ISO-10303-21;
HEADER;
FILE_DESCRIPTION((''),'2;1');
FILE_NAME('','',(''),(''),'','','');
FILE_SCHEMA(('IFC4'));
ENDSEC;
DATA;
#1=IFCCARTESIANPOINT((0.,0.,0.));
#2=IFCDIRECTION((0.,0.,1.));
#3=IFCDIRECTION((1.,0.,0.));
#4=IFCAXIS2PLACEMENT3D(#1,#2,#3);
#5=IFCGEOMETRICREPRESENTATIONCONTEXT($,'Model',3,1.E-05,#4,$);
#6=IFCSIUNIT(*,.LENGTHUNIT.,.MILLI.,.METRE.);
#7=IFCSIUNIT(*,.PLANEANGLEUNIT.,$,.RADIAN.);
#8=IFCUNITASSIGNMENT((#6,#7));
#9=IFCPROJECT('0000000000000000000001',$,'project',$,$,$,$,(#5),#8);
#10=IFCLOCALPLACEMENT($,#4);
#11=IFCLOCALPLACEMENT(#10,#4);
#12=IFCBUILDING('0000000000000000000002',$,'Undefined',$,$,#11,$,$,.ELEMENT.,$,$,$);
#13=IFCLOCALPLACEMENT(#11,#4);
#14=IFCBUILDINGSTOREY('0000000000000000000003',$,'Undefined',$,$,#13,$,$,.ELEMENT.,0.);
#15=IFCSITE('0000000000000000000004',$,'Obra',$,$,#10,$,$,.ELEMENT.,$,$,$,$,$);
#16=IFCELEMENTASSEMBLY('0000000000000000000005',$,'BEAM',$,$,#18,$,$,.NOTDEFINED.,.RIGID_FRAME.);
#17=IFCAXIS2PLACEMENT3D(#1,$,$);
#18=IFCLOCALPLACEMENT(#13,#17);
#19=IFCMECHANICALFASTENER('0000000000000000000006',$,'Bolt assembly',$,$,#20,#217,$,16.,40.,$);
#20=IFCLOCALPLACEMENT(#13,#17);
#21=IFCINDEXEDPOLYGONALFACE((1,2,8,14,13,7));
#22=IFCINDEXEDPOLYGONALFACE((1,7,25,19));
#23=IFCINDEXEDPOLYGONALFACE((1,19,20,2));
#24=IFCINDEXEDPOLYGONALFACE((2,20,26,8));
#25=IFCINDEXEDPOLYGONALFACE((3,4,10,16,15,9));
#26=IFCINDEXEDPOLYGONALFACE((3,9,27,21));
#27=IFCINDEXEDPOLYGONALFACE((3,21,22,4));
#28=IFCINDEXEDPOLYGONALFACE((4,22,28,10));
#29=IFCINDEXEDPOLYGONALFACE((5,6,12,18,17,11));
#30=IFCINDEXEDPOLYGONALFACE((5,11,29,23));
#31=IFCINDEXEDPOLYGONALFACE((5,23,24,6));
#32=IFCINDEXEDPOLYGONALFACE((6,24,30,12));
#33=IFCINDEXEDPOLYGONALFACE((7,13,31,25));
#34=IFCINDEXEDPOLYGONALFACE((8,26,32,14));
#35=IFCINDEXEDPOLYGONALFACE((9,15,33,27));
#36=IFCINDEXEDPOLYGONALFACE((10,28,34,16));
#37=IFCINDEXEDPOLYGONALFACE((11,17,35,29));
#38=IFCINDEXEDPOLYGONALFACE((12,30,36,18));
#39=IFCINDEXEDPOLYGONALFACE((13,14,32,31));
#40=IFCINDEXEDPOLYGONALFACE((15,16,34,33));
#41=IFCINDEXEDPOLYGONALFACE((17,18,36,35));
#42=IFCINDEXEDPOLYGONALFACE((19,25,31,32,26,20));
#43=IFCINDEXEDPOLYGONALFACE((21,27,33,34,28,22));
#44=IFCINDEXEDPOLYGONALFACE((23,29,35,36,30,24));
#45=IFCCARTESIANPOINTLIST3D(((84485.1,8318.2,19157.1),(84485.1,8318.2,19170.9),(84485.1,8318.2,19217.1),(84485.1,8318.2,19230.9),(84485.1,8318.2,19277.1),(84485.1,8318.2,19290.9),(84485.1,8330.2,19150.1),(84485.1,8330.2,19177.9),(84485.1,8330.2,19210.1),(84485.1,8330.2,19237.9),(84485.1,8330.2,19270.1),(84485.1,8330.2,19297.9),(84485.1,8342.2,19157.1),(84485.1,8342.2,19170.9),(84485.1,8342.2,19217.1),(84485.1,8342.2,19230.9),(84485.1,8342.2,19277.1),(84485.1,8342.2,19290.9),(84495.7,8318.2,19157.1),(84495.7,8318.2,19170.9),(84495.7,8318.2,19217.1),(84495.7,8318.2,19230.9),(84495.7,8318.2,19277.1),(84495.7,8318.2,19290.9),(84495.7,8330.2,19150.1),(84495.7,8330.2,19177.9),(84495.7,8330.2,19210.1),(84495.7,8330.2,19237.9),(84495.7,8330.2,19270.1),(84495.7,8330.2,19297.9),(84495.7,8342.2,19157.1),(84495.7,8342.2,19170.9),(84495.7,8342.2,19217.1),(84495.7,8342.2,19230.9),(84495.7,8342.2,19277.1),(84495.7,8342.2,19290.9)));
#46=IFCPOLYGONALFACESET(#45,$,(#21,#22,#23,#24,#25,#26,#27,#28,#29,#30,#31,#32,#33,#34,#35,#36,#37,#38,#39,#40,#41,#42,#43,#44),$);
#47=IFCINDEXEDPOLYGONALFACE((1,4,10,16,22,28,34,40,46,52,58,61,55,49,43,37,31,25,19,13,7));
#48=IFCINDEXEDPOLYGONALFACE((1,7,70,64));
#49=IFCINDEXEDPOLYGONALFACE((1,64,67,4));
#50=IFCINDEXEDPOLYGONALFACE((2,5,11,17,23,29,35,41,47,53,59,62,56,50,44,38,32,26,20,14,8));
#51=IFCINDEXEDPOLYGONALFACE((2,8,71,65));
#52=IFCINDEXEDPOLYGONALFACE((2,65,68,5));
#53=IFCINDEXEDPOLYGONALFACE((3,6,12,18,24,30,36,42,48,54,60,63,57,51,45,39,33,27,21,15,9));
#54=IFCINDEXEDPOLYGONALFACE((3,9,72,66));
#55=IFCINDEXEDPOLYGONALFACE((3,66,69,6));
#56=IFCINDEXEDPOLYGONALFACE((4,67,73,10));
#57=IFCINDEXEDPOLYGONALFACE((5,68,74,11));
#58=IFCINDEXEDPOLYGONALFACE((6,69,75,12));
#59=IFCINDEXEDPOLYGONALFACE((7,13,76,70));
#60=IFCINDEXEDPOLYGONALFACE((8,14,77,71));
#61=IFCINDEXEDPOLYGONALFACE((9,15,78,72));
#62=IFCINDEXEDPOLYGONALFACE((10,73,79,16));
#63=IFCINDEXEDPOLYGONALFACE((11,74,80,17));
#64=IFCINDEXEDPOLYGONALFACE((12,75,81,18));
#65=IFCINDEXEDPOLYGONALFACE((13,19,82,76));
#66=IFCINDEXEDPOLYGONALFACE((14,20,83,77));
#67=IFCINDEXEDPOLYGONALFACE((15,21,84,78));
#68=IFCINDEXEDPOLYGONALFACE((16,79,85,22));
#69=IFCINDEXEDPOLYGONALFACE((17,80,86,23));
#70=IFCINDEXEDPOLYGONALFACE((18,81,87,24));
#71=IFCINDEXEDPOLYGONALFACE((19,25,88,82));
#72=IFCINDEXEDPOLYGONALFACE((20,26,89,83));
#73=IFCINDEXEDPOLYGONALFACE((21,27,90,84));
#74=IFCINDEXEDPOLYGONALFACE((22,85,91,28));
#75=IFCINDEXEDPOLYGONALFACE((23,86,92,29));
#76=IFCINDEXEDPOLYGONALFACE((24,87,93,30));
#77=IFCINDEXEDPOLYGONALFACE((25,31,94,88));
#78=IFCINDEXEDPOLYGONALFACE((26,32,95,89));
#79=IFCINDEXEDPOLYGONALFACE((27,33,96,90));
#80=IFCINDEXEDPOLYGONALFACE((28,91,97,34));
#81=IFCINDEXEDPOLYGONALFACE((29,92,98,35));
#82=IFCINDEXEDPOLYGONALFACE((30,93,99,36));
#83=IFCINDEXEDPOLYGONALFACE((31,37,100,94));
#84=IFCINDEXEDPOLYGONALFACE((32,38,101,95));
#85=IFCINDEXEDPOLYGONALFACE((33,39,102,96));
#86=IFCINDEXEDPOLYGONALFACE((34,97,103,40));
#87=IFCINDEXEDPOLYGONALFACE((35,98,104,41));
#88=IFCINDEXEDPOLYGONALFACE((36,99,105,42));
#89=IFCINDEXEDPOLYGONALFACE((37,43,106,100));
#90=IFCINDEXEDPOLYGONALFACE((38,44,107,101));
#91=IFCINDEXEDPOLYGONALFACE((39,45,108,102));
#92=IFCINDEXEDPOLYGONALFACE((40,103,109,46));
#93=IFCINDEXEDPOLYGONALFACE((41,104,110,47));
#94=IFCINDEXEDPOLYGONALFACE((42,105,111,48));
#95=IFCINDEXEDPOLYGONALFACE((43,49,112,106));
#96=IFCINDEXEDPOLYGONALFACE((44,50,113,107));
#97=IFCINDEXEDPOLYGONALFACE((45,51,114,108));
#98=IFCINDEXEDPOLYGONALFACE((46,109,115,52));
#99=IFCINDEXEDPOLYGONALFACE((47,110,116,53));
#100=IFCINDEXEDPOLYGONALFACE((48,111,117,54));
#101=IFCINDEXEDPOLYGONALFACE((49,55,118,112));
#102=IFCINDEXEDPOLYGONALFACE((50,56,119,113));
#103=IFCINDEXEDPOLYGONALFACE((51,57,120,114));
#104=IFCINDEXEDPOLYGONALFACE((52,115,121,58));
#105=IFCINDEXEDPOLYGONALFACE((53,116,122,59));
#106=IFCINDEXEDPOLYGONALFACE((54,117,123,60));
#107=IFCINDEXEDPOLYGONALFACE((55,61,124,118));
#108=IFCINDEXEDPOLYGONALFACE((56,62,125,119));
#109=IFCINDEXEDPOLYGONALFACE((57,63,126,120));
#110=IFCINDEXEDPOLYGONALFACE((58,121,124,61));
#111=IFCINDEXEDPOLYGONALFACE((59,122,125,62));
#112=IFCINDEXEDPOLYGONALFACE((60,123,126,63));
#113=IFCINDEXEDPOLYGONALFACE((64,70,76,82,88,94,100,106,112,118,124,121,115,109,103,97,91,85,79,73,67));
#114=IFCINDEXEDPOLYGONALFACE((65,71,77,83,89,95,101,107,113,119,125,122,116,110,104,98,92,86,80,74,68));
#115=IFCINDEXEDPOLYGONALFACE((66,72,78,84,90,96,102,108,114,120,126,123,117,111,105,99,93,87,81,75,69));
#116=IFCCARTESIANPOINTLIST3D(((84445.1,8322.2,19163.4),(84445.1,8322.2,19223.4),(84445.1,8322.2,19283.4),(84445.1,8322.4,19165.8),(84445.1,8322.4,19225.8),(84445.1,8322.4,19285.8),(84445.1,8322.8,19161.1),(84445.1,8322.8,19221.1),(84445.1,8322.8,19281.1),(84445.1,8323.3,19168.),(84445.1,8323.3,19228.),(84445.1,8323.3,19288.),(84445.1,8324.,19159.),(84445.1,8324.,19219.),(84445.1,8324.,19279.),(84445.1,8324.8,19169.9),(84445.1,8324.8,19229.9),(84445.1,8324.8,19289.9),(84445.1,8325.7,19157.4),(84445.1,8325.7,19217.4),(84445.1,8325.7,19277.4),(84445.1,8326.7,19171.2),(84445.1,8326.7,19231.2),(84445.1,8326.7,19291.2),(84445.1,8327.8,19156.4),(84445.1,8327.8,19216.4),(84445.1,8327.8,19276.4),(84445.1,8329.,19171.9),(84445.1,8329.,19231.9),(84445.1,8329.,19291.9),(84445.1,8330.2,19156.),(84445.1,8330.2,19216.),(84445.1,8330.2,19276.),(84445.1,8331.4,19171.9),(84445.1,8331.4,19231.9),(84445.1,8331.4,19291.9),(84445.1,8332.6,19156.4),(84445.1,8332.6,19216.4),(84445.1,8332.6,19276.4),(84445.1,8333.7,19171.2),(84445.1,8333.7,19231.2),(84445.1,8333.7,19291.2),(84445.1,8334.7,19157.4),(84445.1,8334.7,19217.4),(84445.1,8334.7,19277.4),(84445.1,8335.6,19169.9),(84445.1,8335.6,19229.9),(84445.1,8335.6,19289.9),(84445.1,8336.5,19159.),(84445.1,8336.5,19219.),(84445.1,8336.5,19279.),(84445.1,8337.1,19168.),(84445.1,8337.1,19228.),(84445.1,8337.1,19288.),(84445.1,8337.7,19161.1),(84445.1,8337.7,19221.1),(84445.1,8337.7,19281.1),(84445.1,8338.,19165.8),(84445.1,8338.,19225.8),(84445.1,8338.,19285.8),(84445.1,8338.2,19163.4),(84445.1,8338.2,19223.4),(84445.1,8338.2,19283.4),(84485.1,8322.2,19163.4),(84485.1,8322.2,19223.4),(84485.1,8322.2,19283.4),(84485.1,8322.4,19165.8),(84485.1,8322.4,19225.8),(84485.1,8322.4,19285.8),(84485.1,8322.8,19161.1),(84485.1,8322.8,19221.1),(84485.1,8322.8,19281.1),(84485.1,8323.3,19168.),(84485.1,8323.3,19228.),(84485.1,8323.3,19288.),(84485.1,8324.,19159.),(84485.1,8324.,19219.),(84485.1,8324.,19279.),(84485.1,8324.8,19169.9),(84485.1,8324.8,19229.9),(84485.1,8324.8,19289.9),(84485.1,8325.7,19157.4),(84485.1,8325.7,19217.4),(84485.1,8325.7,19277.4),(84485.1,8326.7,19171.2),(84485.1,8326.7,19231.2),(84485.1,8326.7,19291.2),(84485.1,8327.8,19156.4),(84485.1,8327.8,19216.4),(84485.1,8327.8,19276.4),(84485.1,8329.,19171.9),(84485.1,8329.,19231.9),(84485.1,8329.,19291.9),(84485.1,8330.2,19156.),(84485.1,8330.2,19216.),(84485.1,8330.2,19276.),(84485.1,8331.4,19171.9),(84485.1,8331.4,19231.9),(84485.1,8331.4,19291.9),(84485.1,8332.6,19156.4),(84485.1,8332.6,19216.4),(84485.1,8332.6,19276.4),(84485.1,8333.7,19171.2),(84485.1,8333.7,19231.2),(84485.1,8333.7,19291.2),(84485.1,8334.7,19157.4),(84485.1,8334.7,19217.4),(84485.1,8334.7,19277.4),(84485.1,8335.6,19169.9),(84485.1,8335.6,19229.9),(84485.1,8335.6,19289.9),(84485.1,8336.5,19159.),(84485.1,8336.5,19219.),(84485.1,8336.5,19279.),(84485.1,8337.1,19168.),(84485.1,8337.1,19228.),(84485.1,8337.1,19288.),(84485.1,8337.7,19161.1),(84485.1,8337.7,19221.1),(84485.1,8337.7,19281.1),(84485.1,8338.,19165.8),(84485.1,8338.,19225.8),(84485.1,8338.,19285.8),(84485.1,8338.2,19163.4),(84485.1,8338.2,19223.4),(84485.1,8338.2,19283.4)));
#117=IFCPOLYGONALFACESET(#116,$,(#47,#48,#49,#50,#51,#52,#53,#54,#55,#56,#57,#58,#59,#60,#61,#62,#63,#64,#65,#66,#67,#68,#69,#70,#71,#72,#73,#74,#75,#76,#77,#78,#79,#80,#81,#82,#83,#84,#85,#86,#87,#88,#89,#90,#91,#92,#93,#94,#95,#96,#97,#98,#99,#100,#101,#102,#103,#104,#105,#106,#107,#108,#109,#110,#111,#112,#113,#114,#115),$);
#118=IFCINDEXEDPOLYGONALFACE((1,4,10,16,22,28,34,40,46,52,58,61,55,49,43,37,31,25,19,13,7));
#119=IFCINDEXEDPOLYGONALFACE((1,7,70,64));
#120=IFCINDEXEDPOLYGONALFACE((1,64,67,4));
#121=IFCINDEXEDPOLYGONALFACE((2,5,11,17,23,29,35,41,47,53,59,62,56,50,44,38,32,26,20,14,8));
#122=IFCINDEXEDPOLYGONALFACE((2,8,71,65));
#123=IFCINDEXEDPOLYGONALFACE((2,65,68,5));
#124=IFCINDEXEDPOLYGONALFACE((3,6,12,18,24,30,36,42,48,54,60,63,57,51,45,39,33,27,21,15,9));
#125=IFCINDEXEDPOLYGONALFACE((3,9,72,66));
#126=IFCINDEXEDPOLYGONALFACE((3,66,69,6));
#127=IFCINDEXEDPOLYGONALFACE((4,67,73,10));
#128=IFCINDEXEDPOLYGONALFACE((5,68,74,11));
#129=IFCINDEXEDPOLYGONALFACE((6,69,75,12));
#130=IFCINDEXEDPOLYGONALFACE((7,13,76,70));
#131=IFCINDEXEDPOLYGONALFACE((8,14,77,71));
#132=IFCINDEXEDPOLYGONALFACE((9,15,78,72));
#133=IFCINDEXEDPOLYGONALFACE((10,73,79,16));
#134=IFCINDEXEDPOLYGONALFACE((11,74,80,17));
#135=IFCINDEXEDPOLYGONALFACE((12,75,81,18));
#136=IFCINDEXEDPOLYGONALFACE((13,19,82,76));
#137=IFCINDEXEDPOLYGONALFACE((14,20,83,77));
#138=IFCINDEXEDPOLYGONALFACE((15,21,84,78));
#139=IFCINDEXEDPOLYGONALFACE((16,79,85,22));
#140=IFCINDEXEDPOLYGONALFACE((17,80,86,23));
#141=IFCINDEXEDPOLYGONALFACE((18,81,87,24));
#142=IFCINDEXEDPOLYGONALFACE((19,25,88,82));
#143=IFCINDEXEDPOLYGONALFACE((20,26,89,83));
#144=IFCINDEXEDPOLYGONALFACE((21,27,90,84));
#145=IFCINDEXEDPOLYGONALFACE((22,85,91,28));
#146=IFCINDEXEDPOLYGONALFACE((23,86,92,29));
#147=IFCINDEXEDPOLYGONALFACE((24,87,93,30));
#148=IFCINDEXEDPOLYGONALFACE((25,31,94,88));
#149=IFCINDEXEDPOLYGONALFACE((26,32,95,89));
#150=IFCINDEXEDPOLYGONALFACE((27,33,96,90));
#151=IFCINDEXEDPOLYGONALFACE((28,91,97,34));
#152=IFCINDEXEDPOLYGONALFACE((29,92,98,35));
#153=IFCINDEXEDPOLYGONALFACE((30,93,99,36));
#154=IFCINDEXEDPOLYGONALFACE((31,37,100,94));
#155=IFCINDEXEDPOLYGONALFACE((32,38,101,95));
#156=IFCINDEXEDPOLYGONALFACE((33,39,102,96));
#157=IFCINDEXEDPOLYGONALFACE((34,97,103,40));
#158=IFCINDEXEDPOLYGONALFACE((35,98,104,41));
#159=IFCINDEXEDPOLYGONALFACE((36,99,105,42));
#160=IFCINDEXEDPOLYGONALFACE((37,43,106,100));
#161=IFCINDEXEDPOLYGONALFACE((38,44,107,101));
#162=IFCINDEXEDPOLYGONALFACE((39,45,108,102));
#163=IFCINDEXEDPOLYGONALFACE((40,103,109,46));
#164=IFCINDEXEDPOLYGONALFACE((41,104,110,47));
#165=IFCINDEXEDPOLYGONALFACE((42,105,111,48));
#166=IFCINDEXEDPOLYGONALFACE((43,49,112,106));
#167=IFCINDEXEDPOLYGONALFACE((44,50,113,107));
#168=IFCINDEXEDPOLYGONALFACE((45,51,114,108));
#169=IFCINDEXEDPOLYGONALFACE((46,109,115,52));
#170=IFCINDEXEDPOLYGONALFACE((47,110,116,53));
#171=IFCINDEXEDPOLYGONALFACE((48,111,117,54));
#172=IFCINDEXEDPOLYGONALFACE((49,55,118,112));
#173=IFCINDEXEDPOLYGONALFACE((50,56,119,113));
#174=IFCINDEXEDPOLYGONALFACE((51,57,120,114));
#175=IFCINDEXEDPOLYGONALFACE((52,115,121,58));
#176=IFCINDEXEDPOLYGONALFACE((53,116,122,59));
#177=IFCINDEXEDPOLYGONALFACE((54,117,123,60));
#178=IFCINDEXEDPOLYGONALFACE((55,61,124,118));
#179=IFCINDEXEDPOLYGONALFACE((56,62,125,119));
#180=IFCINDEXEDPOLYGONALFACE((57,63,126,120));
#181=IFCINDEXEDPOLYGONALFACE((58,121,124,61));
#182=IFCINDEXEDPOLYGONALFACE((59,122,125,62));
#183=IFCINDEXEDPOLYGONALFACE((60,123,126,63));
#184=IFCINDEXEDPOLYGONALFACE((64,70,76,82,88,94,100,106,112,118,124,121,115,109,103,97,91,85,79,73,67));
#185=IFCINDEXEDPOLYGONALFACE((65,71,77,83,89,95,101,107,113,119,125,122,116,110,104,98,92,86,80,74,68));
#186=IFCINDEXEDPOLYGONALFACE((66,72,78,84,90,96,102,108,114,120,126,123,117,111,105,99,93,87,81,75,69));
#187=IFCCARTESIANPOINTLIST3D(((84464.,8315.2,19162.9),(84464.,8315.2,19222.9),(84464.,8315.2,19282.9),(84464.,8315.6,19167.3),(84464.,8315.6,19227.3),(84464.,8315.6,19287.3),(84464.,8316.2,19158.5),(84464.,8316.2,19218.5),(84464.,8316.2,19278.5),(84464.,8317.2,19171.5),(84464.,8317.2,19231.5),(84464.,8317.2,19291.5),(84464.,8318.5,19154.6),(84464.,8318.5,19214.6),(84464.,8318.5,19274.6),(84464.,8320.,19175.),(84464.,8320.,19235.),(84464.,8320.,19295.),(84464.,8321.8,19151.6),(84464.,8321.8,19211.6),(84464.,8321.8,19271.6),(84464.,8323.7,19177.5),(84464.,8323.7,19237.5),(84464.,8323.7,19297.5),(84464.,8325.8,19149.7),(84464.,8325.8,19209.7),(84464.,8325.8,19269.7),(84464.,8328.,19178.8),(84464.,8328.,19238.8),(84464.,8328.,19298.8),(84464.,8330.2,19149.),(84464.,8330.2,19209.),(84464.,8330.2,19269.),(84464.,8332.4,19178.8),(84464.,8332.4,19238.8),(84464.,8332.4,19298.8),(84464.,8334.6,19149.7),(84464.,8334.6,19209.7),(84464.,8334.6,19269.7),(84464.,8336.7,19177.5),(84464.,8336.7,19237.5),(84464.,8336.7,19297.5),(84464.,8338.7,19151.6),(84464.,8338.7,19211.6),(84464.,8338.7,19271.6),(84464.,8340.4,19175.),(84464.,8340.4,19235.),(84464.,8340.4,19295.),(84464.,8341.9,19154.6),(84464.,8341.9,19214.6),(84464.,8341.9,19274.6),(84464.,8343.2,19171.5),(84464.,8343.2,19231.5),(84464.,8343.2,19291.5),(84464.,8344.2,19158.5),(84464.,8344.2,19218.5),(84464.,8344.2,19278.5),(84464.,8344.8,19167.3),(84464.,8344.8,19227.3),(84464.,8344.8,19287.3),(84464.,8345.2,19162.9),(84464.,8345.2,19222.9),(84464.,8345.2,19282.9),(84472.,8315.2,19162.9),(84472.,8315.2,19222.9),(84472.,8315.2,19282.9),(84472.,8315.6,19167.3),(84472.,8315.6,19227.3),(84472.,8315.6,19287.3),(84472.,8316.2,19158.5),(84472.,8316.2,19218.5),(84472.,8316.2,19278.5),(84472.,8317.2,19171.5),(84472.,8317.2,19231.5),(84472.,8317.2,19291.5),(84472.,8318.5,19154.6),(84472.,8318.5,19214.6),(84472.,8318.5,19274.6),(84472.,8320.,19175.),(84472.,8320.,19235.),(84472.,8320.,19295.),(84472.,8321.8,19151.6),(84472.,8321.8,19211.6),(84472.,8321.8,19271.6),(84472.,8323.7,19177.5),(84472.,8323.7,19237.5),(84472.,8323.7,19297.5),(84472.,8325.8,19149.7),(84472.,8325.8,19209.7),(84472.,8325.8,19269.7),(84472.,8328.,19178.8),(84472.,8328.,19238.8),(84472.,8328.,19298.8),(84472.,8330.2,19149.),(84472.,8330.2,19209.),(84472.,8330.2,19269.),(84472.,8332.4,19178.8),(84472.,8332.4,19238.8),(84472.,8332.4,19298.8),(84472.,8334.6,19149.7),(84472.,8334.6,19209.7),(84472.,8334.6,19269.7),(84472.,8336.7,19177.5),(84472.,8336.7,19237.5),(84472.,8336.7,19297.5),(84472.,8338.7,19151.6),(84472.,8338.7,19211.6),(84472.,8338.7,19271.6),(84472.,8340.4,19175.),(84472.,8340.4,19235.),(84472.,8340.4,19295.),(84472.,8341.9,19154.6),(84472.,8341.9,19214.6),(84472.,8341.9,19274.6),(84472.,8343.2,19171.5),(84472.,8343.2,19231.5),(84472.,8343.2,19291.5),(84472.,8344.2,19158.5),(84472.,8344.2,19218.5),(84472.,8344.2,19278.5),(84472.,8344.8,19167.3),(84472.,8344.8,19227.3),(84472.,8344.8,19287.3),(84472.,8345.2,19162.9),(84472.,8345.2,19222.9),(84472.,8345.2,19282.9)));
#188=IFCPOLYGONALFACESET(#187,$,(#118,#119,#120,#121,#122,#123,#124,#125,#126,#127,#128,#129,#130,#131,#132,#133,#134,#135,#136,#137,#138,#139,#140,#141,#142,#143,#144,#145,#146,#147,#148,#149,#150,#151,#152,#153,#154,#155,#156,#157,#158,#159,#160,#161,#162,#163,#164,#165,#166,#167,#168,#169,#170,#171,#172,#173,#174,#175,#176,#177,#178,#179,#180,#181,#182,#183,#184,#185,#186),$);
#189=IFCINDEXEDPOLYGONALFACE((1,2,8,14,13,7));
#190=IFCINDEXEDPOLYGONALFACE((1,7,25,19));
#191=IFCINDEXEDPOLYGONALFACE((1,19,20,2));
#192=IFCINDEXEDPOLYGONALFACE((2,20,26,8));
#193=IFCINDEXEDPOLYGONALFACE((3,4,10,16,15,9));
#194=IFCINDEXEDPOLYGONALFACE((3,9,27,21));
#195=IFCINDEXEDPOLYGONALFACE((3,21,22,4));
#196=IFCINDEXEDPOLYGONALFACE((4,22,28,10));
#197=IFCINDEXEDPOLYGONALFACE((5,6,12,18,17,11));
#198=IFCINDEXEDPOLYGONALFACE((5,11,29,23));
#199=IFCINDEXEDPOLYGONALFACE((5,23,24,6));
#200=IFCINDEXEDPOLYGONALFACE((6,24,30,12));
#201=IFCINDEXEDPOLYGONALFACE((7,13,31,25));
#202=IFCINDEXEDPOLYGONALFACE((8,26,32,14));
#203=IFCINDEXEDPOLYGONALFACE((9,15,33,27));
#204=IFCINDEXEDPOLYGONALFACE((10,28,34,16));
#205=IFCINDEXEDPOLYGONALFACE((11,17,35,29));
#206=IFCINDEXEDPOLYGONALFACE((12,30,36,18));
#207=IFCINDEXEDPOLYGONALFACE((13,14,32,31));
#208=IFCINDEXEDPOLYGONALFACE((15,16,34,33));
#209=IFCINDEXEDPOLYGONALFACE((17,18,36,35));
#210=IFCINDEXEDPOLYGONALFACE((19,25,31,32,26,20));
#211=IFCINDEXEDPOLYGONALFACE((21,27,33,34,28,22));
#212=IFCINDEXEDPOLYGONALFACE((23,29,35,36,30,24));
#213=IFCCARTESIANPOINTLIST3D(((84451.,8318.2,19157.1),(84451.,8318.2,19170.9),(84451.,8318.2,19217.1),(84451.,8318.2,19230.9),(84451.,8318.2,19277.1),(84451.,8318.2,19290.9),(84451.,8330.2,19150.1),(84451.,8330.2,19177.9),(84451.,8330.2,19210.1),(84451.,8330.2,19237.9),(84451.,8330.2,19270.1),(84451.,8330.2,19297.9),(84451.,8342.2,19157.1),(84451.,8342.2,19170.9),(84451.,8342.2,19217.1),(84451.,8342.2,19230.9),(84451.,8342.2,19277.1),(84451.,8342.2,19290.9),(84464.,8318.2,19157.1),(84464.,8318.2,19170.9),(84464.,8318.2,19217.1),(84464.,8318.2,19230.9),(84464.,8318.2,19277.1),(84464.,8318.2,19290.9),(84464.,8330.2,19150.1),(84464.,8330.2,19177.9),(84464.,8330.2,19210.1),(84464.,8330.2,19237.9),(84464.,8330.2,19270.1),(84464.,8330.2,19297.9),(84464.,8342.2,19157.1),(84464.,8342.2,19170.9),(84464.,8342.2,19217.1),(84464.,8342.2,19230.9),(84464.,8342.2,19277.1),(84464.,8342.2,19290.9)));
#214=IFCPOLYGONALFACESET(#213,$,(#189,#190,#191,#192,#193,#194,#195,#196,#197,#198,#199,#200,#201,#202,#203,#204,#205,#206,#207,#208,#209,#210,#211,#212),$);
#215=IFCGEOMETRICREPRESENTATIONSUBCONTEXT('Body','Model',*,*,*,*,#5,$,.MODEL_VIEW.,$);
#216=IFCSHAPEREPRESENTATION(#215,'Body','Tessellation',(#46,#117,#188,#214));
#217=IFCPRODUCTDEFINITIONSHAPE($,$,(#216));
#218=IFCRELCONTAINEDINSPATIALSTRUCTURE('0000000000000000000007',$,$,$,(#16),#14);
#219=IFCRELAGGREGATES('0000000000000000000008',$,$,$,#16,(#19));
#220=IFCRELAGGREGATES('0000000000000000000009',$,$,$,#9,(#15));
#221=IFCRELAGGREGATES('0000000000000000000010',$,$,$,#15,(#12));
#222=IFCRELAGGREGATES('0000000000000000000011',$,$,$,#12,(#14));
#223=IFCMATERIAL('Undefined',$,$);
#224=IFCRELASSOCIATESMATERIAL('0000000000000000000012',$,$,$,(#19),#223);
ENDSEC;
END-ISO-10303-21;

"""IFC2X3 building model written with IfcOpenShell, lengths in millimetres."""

from ifc_helpers import new_model, si_unit, frame, origin_with_axes, origin_2d_with_axis, place, context, subcontext, project, spatial, polyline, circle, outline, extrude, source, transform, mapped, material, element, aggregate, save


model = new_model("IFC2X3")

# Units and contexts
model_context = context("Model", 3, precision=1e-05, world=origin_with_axes())
body_context = subcontext(model_context, "Body", "Model", "MODEL_VIEW")
ifc_project = project(units=[si_unit("LENGTHUNIT", "METRE", prefix="MILLI"), si_unit("PLANEANGLEUNIT", "RADIAN")], contexts=[model_context])

# Site, building, storey
site_placement = place(None, origin_with_axes())
site = spatial("IfcSite", under=ifc_project, at=site_placement, Name="Obra", CompositionType="ELEMENT")
building_placement = place(site_placement, origin_with_axes())
building = spatial("IfcBuilding", under=site, at=building_placement, Name="Undefined", CompositionType="ELEMENT")
storey_placement = place(building_placement, origin_with_axes())
storey = spatial("IfcBuildingStorey", under=building, at=storey_placement, Name="Undefined", CompositionType="ELEMENT", Elevation=0.0)

# Shared definitions
ifc_material_1 = material(Name="Undefined")

# Element assembly, mechanical fastener
assembly_1_placement = place(storey_placement, origin_with_axes())
assembly_1 = element("IfcElementAssembly", 1, at=assembly_1_placement, inside=storey, Name="BEAM", AssemblyPlace="NOTDEFINED", PredefinedType="RIGID_FRAME")
shared_shape_1 = source(origin_with_axes(), body_context, "Body", "SweptSolid", [
    extrude(outline(polyline([(13.9, 0.0), (6.9, 12.0), (-6.9, 12.0), (-13.9, 0.0), (-6.9, -12.0), (6.9, -12.0), (13.9, 0.0)])), frame((0.0, -14.1, 0.0), z_axis=(0.0, 1.0, 0.0), x_axis=(1.0, 0.0, 0.0)), (0.0, 0.0, 1.0), 10.6),
    extrude(circle(Radius=8.0, at=origin_2d_with_axis()), frame((0.0, -3.5, 0.0), z_axis=(0.0, 1.0, 0.0), x_axis=(1.0, 0.0, 0.0)), (0.0, 0.0, 1.0), 40.0),
    extrude(circle(Radius=15.0, at=origin_2d_with_axis()), frame((0.0, 9.5, 0.0), z_axis=(0.0, 1.0, 0.0), x_axis=(1.0, 0.0, 0.0)), (0.0, 0.0, 1.0), 8.0),
    extrude(outline(polyline([(13.9, 0.0), (6.9, 12.0), (-6.9, 12.0), (-13.9, 0.0), (-6.9, -12.0), (6.9, -12.0), (13.9, 0.0)])), frame((0.0, 17.5, 0.0), z_axis=(0.0, 1.0, 0.0), x_axis=(1.0, 0.0, 0.0)), (0.0, 0.0, 1.0), 13.0),
])
mechanical_fastener_1_placement = place(assembly_1_placement, frame((84481.6, 8280.2, 19319.0), z_axis=(0.0, 1.0, 0.0), x_axis=(0.0, 0.0, -1.0)))
mechanical_fastener_1 = element("IfcMechanicalFastener", 2, at=mechanical_fastener_1_placement, material=ifc_material_1, Name="Bolt assembly", NominalDiameter=16.0, NominalLength=40.0, context=body_context, shape_type="MappedRepresentation", body=[
    mapped(shared_shape_1, transform((35.0, 0.0, 50.0))),
    mapped(shared_shape_1, transform((95.0, 0.0, 50.0))),
    mapped(shared_shape_1, transform((155.0, 0.0, 50.0))),
])
aggregate(assembly_1, [mechanical_fastener_1])

save(model, "model.ifc")
